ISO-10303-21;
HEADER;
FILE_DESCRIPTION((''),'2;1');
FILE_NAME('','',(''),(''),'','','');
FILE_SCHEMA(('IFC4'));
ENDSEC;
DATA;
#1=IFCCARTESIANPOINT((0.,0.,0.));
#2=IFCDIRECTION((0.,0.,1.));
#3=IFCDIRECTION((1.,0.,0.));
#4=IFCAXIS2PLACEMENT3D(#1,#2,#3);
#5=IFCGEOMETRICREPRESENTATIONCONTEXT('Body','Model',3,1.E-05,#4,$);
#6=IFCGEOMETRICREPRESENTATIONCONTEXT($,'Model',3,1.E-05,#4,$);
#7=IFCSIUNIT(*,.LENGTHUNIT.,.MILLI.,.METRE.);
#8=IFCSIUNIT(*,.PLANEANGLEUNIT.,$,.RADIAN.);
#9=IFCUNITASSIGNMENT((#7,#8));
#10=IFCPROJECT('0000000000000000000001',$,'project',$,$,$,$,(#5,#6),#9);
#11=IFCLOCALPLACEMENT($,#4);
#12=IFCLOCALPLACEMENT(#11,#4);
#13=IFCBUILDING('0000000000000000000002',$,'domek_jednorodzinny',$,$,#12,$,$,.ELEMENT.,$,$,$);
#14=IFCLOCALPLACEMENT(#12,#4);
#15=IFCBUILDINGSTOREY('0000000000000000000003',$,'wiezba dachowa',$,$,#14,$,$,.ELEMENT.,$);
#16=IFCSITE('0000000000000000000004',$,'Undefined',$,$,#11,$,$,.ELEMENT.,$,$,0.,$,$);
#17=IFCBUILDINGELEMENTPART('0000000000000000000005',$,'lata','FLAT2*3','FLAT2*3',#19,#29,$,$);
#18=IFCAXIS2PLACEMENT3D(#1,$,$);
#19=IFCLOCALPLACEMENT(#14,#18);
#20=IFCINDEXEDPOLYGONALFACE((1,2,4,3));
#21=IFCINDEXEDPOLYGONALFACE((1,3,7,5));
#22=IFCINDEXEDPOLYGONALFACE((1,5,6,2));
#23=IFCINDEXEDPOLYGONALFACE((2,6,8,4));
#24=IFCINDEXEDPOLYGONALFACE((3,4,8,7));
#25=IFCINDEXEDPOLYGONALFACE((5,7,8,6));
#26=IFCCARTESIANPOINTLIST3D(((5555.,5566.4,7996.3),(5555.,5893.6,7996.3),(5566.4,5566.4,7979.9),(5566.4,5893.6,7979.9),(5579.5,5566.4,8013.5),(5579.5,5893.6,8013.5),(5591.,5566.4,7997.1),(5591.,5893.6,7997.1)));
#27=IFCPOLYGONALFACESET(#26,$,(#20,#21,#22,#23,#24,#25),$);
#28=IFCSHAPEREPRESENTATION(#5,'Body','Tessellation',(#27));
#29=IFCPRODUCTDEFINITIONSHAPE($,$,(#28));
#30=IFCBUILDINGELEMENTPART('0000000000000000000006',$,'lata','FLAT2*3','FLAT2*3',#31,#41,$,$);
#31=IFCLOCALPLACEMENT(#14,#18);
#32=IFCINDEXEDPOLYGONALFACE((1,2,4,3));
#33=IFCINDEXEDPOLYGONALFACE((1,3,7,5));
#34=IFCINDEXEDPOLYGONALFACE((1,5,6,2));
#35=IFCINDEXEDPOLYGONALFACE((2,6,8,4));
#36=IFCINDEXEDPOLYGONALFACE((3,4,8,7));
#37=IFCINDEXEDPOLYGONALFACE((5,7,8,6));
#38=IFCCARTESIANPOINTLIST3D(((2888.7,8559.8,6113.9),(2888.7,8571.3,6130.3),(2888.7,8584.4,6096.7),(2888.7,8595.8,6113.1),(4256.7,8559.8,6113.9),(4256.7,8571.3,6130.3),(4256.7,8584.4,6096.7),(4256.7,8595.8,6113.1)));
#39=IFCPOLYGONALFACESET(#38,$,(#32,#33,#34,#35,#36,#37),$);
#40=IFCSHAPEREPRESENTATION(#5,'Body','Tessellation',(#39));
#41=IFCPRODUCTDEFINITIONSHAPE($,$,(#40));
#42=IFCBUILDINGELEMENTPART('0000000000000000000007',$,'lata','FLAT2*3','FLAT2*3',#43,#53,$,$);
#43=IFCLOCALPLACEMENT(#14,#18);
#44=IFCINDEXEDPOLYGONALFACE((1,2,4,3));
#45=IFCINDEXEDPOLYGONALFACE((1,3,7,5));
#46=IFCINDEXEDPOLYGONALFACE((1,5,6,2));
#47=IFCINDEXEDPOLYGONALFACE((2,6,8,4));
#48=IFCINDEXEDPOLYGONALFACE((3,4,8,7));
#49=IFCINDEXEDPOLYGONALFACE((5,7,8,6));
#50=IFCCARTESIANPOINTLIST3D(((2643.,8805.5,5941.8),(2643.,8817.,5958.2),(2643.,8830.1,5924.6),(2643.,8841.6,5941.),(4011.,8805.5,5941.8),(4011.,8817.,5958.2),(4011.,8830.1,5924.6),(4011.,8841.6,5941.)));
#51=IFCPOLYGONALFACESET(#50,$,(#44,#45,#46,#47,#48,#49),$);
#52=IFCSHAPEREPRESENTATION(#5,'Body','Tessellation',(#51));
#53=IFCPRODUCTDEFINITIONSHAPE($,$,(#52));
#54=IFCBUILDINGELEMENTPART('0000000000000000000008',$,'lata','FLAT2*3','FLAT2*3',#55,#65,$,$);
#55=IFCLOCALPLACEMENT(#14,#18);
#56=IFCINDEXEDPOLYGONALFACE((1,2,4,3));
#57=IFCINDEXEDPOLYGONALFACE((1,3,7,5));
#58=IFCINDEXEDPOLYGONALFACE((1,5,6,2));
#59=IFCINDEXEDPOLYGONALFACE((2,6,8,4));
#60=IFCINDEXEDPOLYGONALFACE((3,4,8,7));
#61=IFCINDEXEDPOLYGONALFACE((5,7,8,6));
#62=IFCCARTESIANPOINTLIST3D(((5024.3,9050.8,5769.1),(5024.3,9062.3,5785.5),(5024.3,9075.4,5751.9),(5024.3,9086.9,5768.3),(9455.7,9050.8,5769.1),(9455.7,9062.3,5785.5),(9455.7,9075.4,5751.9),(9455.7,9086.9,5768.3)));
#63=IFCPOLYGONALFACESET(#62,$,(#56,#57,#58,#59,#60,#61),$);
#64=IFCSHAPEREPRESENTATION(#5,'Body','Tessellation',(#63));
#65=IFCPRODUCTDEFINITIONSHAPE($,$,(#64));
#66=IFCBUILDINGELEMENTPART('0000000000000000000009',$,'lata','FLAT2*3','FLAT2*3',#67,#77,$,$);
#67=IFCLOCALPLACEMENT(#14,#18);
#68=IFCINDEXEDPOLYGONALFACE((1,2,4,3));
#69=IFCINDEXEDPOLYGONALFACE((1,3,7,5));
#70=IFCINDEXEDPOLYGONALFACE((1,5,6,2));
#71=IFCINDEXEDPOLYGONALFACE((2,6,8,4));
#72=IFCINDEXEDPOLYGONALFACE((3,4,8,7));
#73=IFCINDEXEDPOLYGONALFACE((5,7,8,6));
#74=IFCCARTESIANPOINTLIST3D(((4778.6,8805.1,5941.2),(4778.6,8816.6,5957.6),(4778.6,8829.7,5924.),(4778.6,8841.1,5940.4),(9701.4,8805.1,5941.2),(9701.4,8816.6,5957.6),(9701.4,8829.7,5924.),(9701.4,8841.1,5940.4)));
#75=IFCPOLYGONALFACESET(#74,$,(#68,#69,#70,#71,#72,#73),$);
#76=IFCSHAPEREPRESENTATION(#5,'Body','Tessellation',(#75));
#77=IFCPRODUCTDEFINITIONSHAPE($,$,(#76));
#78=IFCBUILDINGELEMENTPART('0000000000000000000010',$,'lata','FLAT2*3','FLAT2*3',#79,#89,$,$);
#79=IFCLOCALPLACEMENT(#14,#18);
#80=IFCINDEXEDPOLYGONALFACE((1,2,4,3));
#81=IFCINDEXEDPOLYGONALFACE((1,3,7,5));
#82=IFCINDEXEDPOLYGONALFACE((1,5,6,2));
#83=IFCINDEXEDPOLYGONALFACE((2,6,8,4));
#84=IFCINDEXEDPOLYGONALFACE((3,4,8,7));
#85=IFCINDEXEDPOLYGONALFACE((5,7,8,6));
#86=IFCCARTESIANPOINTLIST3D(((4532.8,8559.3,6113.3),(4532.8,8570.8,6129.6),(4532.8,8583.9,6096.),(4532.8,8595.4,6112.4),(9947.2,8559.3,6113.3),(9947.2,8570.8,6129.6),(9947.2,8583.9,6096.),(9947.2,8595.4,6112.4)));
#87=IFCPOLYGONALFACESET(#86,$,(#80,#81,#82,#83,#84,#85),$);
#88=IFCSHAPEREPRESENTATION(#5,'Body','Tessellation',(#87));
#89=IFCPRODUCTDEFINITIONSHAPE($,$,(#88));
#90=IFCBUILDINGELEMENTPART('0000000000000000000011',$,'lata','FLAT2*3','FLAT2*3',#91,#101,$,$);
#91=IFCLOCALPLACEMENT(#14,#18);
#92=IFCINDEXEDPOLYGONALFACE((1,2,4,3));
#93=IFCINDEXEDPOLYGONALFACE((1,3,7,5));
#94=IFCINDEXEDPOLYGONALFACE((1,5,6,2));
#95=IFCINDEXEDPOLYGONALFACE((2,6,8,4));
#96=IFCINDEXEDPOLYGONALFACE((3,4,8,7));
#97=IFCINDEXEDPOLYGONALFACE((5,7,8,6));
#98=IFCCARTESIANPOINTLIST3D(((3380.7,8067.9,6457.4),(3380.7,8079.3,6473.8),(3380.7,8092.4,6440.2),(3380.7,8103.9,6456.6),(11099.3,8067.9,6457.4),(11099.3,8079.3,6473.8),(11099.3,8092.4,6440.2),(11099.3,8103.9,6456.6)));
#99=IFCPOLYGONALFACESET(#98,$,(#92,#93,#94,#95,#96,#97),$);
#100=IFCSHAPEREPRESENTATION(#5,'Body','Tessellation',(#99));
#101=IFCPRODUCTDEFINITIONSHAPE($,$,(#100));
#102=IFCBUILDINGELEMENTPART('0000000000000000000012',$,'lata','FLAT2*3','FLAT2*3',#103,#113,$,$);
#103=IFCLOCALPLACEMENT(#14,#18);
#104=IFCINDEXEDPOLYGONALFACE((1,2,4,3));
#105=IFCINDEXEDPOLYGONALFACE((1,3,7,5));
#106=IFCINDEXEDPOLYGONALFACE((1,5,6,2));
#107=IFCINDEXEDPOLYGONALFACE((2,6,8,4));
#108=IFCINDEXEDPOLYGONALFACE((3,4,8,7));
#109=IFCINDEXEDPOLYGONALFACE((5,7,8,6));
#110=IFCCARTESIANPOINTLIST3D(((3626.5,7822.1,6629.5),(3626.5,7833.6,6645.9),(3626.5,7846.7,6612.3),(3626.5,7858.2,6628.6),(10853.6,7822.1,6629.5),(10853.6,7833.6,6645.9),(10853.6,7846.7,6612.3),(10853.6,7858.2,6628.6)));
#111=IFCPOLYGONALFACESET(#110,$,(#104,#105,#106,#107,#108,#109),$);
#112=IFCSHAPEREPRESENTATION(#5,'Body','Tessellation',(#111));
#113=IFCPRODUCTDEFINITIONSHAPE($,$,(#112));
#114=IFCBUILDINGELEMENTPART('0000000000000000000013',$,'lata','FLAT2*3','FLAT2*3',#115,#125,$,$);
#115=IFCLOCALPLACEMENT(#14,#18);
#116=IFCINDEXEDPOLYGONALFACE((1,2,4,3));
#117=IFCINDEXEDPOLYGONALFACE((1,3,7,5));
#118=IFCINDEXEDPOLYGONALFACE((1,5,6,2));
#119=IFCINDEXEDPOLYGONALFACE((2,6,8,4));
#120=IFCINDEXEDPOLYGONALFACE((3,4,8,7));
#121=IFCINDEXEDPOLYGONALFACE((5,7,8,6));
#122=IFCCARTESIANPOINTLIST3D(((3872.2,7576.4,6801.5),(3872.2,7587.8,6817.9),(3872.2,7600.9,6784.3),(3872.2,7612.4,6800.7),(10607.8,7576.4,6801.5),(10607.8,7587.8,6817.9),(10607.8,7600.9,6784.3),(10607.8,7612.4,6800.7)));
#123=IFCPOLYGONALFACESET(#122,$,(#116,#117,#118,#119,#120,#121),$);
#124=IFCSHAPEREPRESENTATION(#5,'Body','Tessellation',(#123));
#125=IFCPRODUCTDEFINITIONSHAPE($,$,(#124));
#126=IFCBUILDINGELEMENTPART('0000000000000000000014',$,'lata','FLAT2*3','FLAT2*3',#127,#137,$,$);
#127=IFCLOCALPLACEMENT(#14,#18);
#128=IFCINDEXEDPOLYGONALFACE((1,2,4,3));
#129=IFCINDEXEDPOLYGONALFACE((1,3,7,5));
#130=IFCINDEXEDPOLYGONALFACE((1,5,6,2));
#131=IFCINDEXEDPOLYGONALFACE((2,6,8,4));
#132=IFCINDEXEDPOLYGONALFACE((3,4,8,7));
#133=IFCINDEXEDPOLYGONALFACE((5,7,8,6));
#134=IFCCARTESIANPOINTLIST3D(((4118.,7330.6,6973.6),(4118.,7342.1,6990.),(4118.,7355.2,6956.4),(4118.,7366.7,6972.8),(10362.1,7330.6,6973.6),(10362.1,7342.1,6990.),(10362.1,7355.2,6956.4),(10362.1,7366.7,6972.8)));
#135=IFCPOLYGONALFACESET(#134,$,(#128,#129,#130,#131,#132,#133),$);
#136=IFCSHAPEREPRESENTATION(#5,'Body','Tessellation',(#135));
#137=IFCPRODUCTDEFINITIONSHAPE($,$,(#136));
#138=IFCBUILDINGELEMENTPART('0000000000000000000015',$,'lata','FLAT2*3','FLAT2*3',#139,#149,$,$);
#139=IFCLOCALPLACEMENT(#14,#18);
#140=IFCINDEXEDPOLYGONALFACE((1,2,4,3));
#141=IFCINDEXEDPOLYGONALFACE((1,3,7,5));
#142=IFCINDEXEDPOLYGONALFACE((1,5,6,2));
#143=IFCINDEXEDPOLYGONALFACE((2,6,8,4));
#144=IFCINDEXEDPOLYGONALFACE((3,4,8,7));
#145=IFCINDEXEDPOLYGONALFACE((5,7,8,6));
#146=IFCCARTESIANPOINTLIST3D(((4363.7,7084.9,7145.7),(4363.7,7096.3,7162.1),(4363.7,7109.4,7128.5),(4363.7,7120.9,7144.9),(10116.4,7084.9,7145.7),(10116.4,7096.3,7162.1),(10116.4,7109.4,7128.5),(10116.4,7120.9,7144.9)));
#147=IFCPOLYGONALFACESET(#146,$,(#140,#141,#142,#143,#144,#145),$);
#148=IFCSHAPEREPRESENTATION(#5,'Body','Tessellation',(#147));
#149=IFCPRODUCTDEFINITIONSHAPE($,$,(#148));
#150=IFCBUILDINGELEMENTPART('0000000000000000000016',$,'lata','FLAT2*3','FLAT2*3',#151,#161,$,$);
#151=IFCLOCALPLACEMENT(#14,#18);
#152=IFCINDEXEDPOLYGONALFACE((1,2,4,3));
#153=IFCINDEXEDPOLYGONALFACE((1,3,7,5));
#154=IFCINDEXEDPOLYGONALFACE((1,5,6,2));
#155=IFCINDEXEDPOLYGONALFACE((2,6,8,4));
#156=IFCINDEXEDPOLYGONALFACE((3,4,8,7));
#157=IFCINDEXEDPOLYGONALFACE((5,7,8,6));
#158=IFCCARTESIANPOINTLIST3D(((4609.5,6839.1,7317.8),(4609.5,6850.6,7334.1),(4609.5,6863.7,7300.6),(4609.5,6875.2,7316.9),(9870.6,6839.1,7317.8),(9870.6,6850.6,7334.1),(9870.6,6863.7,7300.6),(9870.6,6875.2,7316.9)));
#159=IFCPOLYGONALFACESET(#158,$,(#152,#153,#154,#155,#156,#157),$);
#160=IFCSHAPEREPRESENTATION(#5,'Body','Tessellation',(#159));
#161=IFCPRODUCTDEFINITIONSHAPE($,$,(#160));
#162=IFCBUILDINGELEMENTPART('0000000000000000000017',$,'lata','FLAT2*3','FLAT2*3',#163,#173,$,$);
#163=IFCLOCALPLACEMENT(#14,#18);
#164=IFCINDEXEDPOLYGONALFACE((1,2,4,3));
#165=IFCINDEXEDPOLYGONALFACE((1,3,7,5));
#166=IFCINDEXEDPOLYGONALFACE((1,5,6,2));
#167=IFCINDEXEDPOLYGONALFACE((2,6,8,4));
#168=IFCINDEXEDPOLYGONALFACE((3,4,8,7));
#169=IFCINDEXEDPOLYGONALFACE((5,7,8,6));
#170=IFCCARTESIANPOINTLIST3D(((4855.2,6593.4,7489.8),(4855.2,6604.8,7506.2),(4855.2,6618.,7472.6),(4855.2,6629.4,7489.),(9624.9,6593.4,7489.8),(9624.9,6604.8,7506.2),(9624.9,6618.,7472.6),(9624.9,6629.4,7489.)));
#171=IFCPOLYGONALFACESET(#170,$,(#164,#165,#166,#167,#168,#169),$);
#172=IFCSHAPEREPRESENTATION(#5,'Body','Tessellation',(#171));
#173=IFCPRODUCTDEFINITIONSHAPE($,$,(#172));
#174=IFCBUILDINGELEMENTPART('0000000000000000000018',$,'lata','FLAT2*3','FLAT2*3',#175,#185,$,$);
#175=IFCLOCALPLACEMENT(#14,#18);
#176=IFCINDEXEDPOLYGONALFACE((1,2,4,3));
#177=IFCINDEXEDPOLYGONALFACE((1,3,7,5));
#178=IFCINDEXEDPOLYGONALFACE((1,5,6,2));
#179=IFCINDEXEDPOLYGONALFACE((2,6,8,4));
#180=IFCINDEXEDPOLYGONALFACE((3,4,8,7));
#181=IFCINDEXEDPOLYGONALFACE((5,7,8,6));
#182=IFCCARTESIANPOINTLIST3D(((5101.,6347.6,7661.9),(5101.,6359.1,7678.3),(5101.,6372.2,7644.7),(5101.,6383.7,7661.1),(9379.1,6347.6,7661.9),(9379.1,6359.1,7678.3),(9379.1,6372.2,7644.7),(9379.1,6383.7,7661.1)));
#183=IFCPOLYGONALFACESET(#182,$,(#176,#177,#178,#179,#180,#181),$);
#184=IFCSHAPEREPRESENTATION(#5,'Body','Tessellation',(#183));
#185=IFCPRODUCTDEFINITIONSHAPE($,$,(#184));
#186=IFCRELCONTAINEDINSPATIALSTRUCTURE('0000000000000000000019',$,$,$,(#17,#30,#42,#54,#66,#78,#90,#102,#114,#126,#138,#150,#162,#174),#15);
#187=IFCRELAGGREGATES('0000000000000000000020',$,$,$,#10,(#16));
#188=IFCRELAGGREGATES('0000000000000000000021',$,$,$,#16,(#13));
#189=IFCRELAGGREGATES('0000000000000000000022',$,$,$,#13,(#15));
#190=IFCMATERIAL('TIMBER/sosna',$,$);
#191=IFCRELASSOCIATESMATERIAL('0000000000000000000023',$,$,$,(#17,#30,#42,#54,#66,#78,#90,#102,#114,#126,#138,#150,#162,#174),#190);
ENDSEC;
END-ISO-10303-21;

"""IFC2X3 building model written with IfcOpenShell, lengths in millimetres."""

from ifc_helpers import new_model, si_unit, frame, origin_with_axes, origin_2d_with_axis, place, context, project, spatial, rectangle, extrude, material, element, save


model = new_model("IFC2X3")

# Units and contexts
model_context_1 = context("Model", 3, precision=1e-05, world=origin_with_axes(), identifier="Body")
model_context_2 = context("Model", 3, precision=1e-05, world=origin_with_axes())
ifc_project = project(units=[si_unit("LENGTHUNIT", "METRE", prefix="MILLI"), si_unit("PLANEANGLEUNIT", "RADIAN")], contexts=[model_context_1, model_context_2])

# Site, building, storey
site_placement = place(None, origin_with_axes())
site = spatial("IfcSite", under=ifc_project, at=site_placement, Name="Undefined", CompositionType="ELEMENT", RefElevation=0.0)
building_placement = place(site_placement, origin_with_axes())
building = spatial("IfcBuilding", under=site, at=building_placement, Name="domek_jednorodzinny", CompositionType="ELEMENT")
storey_placement = place(building_placement, origin_with_axes())
storey = spatial("IfcBuildingStorey", under=building, at=storey_placement, Name="wiezba dachowa", CompositionType="ELEMENT")

# Building element parts
ifc_material = material(Name="TIMBER/sosna")
building_element_part_1_placement = place(storey_placement, frame((5573.0, 5566.4, 7996.7), z_axis=(0.819152, 0.0, 0.573576), x_axis=(0.0, 1.0, 0.0)))
element("IfcBuildingElementPart", 1, at=building_element_part_1_placement, inside=storey, material=ifc_material, Name="lata", Description="FLAT2*3", ObjectType="FLAT2*3", context=model_context_1, shape_type="SweptSolid", body=[
    extrude(rectangle(XDim=20.0, YDim=30.0, at=origin_2d_with_axis()), frame((327.2, 0.0, 0.0), z_axis=(-1.0, 0.0, 0.0), x_axis=(0.0, -1.0, 0.0)), (0.0, 0.0, 1.0), 327.2),
])
building_element_part_2_placement = place(storey_placement, frame((4256.7, 8577.8, 6113.5), z_axis=(0.0, -0.819154, 0.573574), x_axis=(-1.0, 0.0, 0.0)))
element("IfcBuildingElementPart", 2, at=building_element_part_2_placement, inside=storey, material=ifc_material, Name="lata", Description="FLAT2*3", ObjectType="FLAT2*3", context=model_context_1, shape_type="SweptSolid", body=[
    extrude(rectangle(XDim=20.0, YDim=30.0, at=origin_2d_with_axis()), frame((1368.0, 0.0, 0.0), z_axis=(-1.0, 0.0, 0.0), x_axis=(0.0, -1.0, 0.0)), (0.0, 0.0, 1.0), 1368.0),
])
building_element_part_3_placement = place(storey_placement, frame((4011.0, 8823.6, 5941.4), z_axis=(0.0, -0.819154, 0.573574), x_axis=(-1.0, 0.0, 0.0)))
element("IfcBuildingElementPart", 3, at=building_element_part_3_placement, inside=storey, material=ifc_material, Name="lata", Description="FLAT2*3", ObjectType="FLAT2*3", context=model_context_1, shape_type="SweptSolid", body=[
    extrude(rectangle(XDim=20.0, YDim=30.0, at=origin_2d_with_axis()), frame((1368.0, 0.0, 0.0), z_axis=(-1.0, 0.0, 0.0), x_axis=(0.0, -1.0, 0.0)), (0.0, 0.0, 1.0), 1368.0),
])
building_element_part_4_placement = place(storey_placement, frame((5024.3, 9068.9, 5768.7), z_axis=(0.0, -0.819154, 0.573574), x_axis=(1.0, 0.0, 0.0)))
element("IfcBuildingElementPart", 4, at=building_element_part_4_placement, inside=storey, material=ifc_material, Name="lata", Description="FLAT2*3", ObjectType="FLAT2*3", context=model_context_1, shape_type="SweptSolid", body=[
    extrude(rectangle(XDim=20.0, YDim=30.0, at=origin_2d_with_axis()), frame((4431.4, 0.0, 0.0), z_axis=(-1.0, 0.0, 0.0), x_axis=(0.0, -1.0, 0.0)), (0.0, 0.0, 1.0), 4431.4),
])
building_element_part_5_placement = place(storey_placement, frame((4778.6, 8823.1, 5940.8), z_axis=(0.0, -0.819154, 0.573574), x_axis=(1.0, 0.0, 0.0)))
element("IfcBuildingElementPart", 5, at=building_element_part_5_placement, inside=storey, material=ifc_material, Name="lata", Description="FLAT2*3", ObjectType="FLAT2*3", context=model_context_1, shape_type="SweptSolid", body=[
    extrude(rectangle(XDim=20.0, YDim=30.0, at=origin_2d_with_axis()), frame((4922.9, 0.0, 0.0), z_axis=(-1.0, 0.0, 0.0), x_axis=(0.0, -1.0, 0.0)), (0.0, 0.0, 1.0), 4922.9),
])
building_element_part_6_placement = place(storey_placement, frame((4532.8, 8577.4, 6112.8), z_axis=(0.0, -0.819154, 0.573574), x_axis=(1.0, 0.0, 0.0)))
element("IfcBuildingElementPart", 6, at=building_element_part_6_placement, inside=storey, material=ifc_material, Name="lata", Description="FLAT2*3", ObjectType="FLAT2*3", context=model_context_1, shape_type="SweptSolid", body=[
    extrude(rectangle(XDim=20.0, YDim=30.0, at=origin_2d_with_axis()), frame((5414.4, 0.0, 0.0), z_axis=(-1.0, 0.0, 0.0), x_axis=(0.0, -1.0, 0.0)), (0.0, 0.0, 1.0), 5414.4),
])
building_element_part_7_placement = place(storey_placement, frame((3380.7, 8085.9, 6457.0), z_axis=(0.0, -0.819154, 0.573574), x_axis=(1.0, 0.0, 0.0)))
element("IfcBuildingElementPart", 7, at=building_element_part_7_placement, inside=storey, material=ifc_material, Name="lata", Description="FLAT2*3", ObjectType="FLAT2*3", context=model_context_1, shape_type="SweptSolid", body=[
    extrude(rectangle(XDim=20.0, YDim=30.0, at=origin_2d_with_axis()), frame((7718.6, 0.0, 0.0), z_axis=(-1.0, 0.0, 0.0), x_axis=(0.0, -1.0, 0.0)), (0.0, 0.0, 1.0), 7718.6),
])
building_element_part_8_placement = place(storey_placement, frame((3626.5, 7840.1, 6629.1), z_axis=(0.0, -0.819154, 0.573574), x_axis=(1.0, 0.0, 0.0)))
element("IfcBuildingElementPart", 8, at=building_element_part_8_placement, inside=storey, material=ifc_material, Name="lata", Description="FLAT2*3", ObjectType="FLAT2*3", context=model_context_1, shape_type="SweptSolid", body=[
    extrude(rectangle(XDim=20.0, YDim=30.0, at=origin_2d_with_axis()), frame((7227.1, 0.0, 0.0), z_axis=(-1.0, 0.0, 0.0), x_axis=(0.0, -1.0, 0.0)), (0.0, 0.0, 1.0), 7227.1),
])
building_element_part_9_placement = place(storey_placement, frame((3872.2, 7594.4, 6801.1), z_axis=(0.0, -0.819154, 0.573574), x_axis=(1.0, 0.0, 0.0)))
element("IfcBuildingElementPart", 9, at=building_element_part_9_placement, inside=storey, material=ifc_material, Name="lata", Description="FLAT2*3", ObjectType="FLAT2*3", context=model_context_1, shape_type="SweptSolid", body=[
    extrude(rectangle(XDim=20.0, YDim=30.0, at=origin_2d_with_axis()), frame((6735.6, 0.0, 0.0), z_axis=(-1.0, 0.0, 0.0), x_axis=(0.0, -1.0, 0.0)), (0.0, 0.0, 1.0), 6735.6),
])
building_element_part_10_placement = place(storey_placement, frame((4118.0, 7348.6, 6973.2), z_axis=(0.0, -0.819154, 0.573574), x_axis=(1.0, 0.0, 0.0)))
element("IfcBuildingElementPart", 10, at=building_element_part_10_placement, inside=storey, material=ifc_material, Name="lata", Description="FLAT2*3", ObjectType="FLAT2*3", context=model_context_1, shape_type="SweptSolid", body=[
    extrude(rectangle(XDim=20.0, YDim=30.0, at=origin_2d_with_axis()), frame((6244.1, 0.0, 0.0), z_axis=(-1.0, 0.0, 0.0), x_axis=(0.0, -1.0, 0.0)), (0.0, 0.0, 1.0), 6244.1),
])
building_element_part_11_placement = place(storey_placement, frame((4363.7, 7102.9, 7145.3), z_axis=(0.0, -0.819154, 0.573574), x_axis=(1.0, 0.0, 0.0)))
element("IfcBuildingElementPart", 11, at=building_element_part_11_placement, inside=storey, material=ifc_material, Name="lata", Description="FLAT2*3", ObjectType="FLAT2*3", context=model_context_1, shape_type="SweptSolid", body=[
    extrude(rectangle(XDim=20.0, YDim=30.0, at=origin_2d_with_axis()), frame((5752.6, 0.0, 0.0), z_axis=(-1.0, 0.0, 0.0), x_axis=(0.0, -1.0, 0.0)), (0.0, 0.0, 1.0), 5752.6),
])
building_element_part_12_placement = place(storey_placement, frame((4609.5, 6857.1, 7317.4), z_axis=(0.0, -0.819154, 0.573574), x_axis=(1.0, 0.0, 0.0)))
element("IfcBuildingElementPart", 12, at=building_element_part_12_placement, inside=storey, material=ifc_material, Name="lata", Description="FLAT2*3", ObjectType="FLAT2*3", context=model_context_1, shape_type="SweptSolid", body=[
    extrude(rectangle(XDim=20.0, YDim=30.0, at=origin_2d_with_axis()), frame((5261.1, 0.0, 0.0), z_axis=(-1.0, 0.0, 0.0), x_axis=(0.0, -1.0, 0.0)), (0.0, 0.0, 1.0), 5261.1),
])
building_element_part_13_placement = place(storey_placement, frame((4855.2, 6611.4, 7489.4), z_axis=(0.0, -0.819154, 0.573574), x_axis=(1.0, 0.0, 0.0)))
element("IfcBuildingElementPart", 13, at=building_element_part_13_placement, inside=storey, material=ifc_material, Name="lata", Description="FLAT2*3", ObjectType="FLAT2*3", context=model_context_1, shape_type="SweptSolid", body=[
    extrude(rectangle(XDim=20.0, YDim=30.0, at=origin_2d_with_axis()), frame((4769.6, 0.0, 0.0), z_axis=(-1.0, 0.0, 0.0), x_axis=(0.0, -1.0, 0.0)), (0.0, 0.0, 1.0), 4769.6),
])
building_element_part_14_placement = place(storey_placement, frame((5101.0, 6365.7, 7661.5), z_axis=(0.0, -0.819154, 0.573574), x_axis=(1.0, 0.0, 0.0)))
element("IfcBuildingElementPart", 14, at=building_element_part_14_placement, inside=storey, material=ifc_material, Name="lata", Description="FLAT2*3", ObjectType="FLAT2*3", context=model_context_1, shape_type="SweptSolid", body=[
    extrude(rectangle(XDim=20.0, YDim=30.0, at=origin_2d_with_axis()), frame((4278.2, 0.0, 0.0), z_axis=(-1.0, 0.0, 0.0), x_axis=(0.0, -1.0, 0.0)), (0.0, 0.0, 1.0), 4278.2),
])

save(model, "model.ifc")
